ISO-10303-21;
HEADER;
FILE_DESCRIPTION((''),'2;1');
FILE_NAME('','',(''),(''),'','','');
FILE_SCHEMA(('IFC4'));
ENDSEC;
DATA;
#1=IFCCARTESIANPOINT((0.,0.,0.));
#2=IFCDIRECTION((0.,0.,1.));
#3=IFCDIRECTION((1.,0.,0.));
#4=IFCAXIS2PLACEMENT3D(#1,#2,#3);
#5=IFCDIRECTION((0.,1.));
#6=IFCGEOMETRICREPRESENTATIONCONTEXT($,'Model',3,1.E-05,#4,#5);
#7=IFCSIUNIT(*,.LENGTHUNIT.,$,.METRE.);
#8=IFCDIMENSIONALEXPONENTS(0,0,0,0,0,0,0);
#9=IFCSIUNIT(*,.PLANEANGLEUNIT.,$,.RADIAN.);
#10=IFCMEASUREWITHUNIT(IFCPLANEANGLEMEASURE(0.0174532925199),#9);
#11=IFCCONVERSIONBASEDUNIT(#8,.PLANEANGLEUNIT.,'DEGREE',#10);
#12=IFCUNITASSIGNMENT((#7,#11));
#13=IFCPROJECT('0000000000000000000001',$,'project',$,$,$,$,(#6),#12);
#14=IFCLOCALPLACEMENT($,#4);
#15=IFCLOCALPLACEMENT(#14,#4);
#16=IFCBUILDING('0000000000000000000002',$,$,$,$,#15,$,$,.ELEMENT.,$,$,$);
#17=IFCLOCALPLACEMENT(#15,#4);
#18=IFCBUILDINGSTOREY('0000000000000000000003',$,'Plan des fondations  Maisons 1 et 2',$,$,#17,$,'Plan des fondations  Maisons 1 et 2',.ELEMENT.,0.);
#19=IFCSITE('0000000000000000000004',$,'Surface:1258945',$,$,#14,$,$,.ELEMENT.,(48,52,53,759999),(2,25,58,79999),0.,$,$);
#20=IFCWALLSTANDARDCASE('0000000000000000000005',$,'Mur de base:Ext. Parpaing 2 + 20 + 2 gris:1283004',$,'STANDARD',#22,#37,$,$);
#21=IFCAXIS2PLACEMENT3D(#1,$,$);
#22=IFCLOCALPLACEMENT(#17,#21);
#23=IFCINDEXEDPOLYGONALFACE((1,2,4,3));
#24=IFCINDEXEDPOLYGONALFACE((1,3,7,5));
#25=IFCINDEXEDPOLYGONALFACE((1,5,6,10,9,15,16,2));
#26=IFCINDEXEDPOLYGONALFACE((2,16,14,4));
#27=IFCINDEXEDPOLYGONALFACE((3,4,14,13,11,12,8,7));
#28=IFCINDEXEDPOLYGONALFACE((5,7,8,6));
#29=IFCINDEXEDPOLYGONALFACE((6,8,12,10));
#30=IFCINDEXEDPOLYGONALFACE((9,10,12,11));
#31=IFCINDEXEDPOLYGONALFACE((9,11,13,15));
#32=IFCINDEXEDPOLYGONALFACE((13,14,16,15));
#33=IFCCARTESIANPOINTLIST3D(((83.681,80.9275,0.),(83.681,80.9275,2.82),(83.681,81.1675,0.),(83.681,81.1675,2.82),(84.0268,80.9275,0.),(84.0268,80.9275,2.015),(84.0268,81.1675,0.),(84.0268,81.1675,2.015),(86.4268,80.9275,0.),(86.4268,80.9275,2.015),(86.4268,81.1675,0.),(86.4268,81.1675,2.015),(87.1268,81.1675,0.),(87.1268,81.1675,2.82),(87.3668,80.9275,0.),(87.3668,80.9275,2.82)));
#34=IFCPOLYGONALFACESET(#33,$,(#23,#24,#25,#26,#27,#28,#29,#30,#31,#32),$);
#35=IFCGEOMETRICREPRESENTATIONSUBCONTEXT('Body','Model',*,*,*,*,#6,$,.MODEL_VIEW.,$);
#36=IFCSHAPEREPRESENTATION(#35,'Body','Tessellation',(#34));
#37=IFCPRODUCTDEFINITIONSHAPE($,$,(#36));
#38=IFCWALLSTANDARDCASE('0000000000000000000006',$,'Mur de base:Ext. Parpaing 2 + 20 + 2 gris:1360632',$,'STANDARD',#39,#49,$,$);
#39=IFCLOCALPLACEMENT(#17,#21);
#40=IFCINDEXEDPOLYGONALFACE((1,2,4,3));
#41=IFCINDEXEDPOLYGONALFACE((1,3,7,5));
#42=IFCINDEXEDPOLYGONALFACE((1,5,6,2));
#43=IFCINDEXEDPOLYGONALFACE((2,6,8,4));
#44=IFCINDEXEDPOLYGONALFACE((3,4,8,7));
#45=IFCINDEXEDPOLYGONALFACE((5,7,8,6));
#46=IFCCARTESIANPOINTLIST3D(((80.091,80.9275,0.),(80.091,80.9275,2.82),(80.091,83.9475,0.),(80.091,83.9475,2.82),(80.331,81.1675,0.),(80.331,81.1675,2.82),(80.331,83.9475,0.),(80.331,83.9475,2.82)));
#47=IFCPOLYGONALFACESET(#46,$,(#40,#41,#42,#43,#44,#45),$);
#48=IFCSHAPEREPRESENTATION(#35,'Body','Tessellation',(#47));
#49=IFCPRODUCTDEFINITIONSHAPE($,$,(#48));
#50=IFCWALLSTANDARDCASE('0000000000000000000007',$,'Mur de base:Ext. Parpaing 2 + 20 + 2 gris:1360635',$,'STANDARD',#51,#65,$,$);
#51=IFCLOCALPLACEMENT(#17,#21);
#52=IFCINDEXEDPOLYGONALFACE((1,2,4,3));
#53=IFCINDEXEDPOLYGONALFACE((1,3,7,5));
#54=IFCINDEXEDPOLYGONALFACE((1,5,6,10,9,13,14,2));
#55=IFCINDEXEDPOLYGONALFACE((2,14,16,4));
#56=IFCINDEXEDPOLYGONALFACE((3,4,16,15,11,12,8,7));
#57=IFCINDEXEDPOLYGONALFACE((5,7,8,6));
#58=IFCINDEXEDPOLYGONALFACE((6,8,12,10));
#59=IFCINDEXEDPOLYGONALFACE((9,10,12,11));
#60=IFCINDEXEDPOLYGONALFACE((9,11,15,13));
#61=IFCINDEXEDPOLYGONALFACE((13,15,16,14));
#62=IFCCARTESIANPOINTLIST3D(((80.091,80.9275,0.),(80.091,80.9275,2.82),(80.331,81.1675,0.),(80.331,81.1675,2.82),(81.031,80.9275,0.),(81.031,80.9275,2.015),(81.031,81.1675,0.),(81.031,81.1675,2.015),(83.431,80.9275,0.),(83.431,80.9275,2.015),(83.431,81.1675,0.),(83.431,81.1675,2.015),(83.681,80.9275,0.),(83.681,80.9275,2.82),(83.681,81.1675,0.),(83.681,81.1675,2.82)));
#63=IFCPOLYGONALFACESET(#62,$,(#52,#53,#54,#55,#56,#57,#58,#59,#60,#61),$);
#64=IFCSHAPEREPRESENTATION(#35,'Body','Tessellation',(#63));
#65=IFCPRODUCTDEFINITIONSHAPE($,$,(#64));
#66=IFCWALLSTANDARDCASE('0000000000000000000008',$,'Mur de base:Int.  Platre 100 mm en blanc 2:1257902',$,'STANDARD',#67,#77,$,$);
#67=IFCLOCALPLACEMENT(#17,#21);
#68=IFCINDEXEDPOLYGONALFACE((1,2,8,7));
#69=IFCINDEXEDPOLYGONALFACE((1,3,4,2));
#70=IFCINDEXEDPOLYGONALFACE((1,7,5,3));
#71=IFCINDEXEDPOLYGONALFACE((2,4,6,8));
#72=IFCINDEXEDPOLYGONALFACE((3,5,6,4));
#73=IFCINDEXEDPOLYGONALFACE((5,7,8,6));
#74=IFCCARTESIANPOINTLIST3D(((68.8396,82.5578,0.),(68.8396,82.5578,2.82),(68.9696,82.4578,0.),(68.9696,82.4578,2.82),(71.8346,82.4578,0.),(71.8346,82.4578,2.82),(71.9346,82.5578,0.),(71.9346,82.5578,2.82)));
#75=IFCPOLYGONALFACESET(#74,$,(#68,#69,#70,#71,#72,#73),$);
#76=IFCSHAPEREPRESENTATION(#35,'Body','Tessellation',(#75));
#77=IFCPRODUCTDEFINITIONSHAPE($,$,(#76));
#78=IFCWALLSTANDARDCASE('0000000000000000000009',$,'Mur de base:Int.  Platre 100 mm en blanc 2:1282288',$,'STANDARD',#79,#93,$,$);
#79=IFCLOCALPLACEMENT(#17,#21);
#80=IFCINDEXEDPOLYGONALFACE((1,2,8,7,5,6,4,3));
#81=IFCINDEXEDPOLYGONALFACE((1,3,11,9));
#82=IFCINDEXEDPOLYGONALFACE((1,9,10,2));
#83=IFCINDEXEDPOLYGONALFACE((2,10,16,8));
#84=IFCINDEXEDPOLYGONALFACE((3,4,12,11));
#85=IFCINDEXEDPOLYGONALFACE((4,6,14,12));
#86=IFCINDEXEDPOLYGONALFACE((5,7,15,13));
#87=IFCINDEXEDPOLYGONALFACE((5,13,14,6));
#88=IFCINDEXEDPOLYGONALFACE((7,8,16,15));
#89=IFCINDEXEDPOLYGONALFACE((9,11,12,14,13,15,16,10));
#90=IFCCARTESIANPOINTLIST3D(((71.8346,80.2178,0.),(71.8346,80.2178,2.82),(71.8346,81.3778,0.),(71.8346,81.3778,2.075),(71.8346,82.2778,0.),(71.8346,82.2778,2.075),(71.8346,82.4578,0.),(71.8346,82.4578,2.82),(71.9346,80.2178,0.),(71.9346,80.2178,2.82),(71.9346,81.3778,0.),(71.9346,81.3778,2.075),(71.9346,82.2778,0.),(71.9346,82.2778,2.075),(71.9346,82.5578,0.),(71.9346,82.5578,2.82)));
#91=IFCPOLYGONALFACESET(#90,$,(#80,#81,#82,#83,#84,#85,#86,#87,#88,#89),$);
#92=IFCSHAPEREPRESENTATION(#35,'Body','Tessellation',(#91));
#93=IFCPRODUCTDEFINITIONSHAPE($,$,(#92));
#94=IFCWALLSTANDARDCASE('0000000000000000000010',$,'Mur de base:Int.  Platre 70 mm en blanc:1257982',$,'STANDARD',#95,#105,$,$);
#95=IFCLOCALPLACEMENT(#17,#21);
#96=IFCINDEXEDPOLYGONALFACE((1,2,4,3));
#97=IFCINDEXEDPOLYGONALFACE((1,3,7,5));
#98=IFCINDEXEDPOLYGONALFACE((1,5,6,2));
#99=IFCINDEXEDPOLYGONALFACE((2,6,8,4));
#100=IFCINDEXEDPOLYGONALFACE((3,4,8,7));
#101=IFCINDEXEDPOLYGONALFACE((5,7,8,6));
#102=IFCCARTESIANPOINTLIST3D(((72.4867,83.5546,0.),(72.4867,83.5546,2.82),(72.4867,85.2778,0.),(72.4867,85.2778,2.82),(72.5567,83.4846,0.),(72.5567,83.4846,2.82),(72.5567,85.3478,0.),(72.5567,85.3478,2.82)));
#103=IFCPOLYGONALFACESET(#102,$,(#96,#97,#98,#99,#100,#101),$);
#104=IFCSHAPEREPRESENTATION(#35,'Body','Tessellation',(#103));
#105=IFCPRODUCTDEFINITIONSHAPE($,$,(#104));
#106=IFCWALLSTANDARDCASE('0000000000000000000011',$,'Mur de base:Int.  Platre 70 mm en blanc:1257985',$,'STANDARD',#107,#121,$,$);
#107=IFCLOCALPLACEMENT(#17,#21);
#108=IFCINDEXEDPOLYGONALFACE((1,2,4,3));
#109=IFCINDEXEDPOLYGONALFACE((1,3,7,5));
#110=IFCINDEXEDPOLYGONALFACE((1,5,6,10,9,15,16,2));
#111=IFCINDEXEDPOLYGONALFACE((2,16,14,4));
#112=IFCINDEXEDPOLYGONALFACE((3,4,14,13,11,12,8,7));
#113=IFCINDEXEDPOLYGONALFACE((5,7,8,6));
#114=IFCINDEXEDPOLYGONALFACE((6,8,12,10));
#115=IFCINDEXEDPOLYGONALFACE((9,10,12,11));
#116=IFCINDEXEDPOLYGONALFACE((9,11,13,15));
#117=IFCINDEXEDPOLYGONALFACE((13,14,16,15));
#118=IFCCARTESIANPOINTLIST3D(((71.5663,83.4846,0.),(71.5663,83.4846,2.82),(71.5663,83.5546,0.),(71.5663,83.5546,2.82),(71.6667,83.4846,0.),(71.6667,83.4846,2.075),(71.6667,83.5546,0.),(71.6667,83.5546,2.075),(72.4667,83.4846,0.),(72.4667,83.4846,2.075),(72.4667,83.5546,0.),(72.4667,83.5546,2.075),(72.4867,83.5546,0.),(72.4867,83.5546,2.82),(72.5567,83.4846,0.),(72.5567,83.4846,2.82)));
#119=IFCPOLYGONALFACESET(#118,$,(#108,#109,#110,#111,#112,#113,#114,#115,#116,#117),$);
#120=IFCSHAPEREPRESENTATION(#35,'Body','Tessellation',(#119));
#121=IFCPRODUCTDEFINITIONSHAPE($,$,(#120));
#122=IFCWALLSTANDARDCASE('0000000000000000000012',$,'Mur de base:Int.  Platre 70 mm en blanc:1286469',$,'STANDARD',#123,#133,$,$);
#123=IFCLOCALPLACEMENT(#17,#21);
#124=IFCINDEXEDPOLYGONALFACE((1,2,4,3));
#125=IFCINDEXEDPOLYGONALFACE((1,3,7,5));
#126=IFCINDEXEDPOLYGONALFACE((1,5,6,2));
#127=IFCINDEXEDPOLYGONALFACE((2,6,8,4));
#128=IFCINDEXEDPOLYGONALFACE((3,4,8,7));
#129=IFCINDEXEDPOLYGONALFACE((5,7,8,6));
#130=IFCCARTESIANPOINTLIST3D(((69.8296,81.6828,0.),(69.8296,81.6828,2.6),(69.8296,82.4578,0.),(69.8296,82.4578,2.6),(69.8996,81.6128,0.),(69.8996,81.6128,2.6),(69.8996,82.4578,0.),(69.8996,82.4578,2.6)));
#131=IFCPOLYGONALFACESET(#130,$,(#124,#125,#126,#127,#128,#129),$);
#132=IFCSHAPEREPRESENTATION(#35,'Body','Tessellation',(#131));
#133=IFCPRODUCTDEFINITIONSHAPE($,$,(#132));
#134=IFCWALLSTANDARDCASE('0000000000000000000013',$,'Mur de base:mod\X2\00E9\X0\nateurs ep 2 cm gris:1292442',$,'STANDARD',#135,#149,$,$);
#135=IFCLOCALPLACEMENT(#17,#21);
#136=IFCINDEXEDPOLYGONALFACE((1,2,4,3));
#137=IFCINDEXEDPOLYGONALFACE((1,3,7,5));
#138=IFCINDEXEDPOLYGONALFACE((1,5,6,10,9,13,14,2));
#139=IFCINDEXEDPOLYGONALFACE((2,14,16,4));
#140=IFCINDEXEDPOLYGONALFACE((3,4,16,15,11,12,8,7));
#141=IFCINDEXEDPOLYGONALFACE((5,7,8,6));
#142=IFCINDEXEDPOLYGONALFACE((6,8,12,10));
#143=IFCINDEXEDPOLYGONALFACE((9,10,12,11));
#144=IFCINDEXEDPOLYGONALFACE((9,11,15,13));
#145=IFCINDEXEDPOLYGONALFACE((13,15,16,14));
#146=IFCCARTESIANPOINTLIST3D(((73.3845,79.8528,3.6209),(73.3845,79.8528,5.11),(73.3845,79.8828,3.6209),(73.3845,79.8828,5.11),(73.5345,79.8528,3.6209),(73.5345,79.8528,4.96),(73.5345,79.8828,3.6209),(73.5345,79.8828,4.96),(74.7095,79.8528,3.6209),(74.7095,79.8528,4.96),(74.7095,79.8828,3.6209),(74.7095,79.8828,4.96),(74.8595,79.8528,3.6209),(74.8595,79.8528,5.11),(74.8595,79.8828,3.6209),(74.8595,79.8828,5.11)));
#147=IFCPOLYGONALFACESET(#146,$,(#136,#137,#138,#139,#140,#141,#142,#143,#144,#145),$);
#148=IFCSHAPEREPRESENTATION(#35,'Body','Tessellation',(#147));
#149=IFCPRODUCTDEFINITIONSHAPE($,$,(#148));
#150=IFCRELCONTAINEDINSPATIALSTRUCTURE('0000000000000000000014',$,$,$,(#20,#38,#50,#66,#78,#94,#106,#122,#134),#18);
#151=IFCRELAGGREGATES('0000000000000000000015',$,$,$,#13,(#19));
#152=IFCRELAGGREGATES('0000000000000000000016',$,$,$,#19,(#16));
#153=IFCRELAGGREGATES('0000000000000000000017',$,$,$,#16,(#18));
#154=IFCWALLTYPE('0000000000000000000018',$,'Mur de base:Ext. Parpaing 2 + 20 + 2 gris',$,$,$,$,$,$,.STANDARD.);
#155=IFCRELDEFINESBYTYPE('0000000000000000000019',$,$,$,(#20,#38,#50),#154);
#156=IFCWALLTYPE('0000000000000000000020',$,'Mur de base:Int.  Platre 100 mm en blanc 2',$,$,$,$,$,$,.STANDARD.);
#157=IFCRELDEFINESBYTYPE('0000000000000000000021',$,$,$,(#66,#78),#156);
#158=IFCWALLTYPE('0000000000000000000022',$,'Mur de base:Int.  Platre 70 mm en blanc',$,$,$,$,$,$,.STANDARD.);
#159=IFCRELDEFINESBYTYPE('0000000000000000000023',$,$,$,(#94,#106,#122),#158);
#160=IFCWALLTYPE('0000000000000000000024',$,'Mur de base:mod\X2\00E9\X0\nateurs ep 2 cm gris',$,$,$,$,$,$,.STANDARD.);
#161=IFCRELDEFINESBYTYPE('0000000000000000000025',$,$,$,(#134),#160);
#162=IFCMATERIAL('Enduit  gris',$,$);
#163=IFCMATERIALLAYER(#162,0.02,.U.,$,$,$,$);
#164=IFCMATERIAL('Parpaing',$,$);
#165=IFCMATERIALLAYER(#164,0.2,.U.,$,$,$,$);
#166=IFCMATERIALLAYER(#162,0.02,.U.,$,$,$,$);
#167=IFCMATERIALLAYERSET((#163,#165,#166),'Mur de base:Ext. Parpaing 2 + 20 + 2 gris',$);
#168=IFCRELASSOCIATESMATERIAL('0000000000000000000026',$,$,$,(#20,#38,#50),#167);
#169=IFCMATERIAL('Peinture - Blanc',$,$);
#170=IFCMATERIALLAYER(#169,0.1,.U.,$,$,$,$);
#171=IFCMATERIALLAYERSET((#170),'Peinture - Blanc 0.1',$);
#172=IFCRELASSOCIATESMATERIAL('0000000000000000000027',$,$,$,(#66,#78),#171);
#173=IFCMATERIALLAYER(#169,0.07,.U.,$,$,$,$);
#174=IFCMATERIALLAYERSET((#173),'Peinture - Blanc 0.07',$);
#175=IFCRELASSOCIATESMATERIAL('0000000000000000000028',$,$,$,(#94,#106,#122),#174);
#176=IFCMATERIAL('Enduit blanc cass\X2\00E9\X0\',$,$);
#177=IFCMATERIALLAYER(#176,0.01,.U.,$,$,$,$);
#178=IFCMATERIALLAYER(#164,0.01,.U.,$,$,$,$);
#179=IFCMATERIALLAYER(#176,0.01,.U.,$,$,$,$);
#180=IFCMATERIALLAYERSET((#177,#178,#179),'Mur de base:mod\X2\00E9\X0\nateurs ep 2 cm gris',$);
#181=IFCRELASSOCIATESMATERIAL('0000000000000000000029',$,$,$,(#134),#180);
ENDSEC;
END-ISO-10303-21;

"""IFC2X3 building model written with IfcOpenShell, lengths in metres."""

from ifc_helpers import new_model, entity, si_unit, converted_unit, direction, frame, origin_with_axes, origin_2d_with_axis, place, context, subcontext, project, spatial, polyline, rectangle, outline, extrude, clip, halfspace, material, layer, layer_set, layer_usage, type_object, element, save


model = new_model("IFC2X3")

# Units and contexts
model_context = context("Model", 3, precision=1e-05, world=origin_with_axes(), true_north=direction((0.0, 1.0)))
body_context = subcontext(model_context, "Body", "Model", "MODEL_VIEW")
ifc_project = project(units=[si_unit("LENGTHUNIT", "METRE"), converted_unit("PLANEANGLEUNIT", "DEGREE", entity("IfcPlaneAngleMeasure", 0.0174532925199), si_unit("PLANEANGLEUNIT", "RADIAN"), dimensions=[0, 0, 0, 0, 0, 0, 0])], contexts=[model_context])

# Site, building, storey
site_placement = place(None, origin_with_axes())
site = spatial("IfcSite", under=ifc_project, at=site_placement, Name="Surface:1258945", CompositionType="ELEMENT", RefLatitude=(48, 52, 53, 759999), RefLongitude=(2, 25, 58, 79999), RefElevation=0.0)
building_placement = place(site_placement, origin_with_axes())
building = spatial("IfcBuilding", under=site, at=building_placement, CompositionType="ELEMENT")
storey_placement = place(building_placement, origin_with_axes())
storey = spatial("IfcBuildingStorey", under=building, at=storey_placement, Name="Plan des fondations  Maisons 1 et 2", LongName="Plan des fondations  Maisons 1 et 2", CompositionType="ELEMENT", Elevation=0.0)

# Shared definitions
ifc_material_1 = material(Name="Parpaing")
ifc_material_2 = material(Name="Enduit  gris")
ifc_layer_1 = layer(ifc_material_2, 0.02, ventilated="UNKNOWN")
ifc_layer_2 = layer(ifc_material_1, 0.2, ventilated="UNKNOWN")
ifc_layer_3 = layer(ifc_material_2, 0.02, ventilated="UNKNOWN")
ifc_layer_set_1 = layer_set([ifc_layer_1, ifc_layer_2, ifc_layer_3], Name="Mur de base:Ext. Parpaing 2 + 20 + 2 gris")
wall_type_1 = type_object("IfcWallType", Name="Mur de base:Ext. Parpaing 2 + 20 + 2 gris", PredefinedType="STANDARD")

# Wall, opening
ifc_layer_usage_1 = layer_usage(ifc_layer_set_1, "AXIS2", "POSITIVE", -0.12)
wall_1_placement = place(storey_placement, frame((83.681, 81.0475, 0.0), z_axis=(0.0, 0.0, 1.0), x_axis=(1.0, 0.0, 0.0)))
wall_1 = element("IfcWallStandardCase", 1, at=wall_1_placement, inside=storey, type_object=wall_type_1, material=ifc_layer_usage_1, Name="Mur de base:Ext. Parpaing 2 + 20 + 2 gris:1283004", ObjectType="STANDARD", context=body_context, shape_type="SweptSolid", body=[
    extrude(outline(polyline([(0.0, -0.12), (3.6858, -0.12), (3.4458, 0.12), (0.0, 0.12), (0.0, -0.12)])), origin_with_axes(), (0.0, 0.0, 1.0), 2.82),
])
opening_1_placement = place(wall_1_placement, frame((1.5458, 0.0, 0.0), z_axis=(0.0, 0.0, 1.0), x_axis=(1.0, 0.0, 0.0)))
element("IfcOpeningElement", 2, at=opening_1_placement, cuts=wall_1, context=body_context, shape_type="SweptSolid", body=[
    extrude(outline(polyline([(-1.2, 2.015), (-1.2, 0.0), (1.2, 0.0), (1.2, 2.015), (-1.2, 2.015)])), frame((0.0, -0.42, 0.0), z_axis=(0.0, 1.0, 0.0), x_axis=(-1.0, 0.0, 0.0)), (0.0, 0.0, 1.0), 0.84),
])

# Wall
ifc_layer_usage_2 = layer_usage(ifc_layer_set_1, "AXIS2", "POSITIVE", -0.12)
wall_2_placement = place(storey_placement, frame((80.211, 81.0475, 0.0), z_axis=(0.0, 0.0, 1.0), x_axis=(0.0, 1.0, 0.0)))
element("IfcWallStandardCase", 3, at=wall_2_placement, inside=storey, type_object=wall_type_1, material=ifc_layer_usage_2, Name="Mur de base:Ext. Parpaing 2 + 20 + 2 gris:1360632", ObjectType="STANDARD", context=body_context, shape_type="SweptSolid", body=[
    extrude(outline(polyline([(0.12, -0.12), (2.9, -0.12), (2.9, 0.12), (-0.12, 0.12), (0.12, -0.12)])), origin_with_axes(), (0.0, 0.0, 1.0), 2.82),
])

# Wall, opening
ifc_layer_usage_3 = layer_usage(ifc_layer_set_1, "AXIS2", "POSITIVE", -0.12)
wall_3_placement = place(storey_placement, frame((83.681, 81.0475, 0.0), z_axis=(0.0, 0.0, 1.0), x_axis=(-1.0, 0.0, 0.0)))
wall_3 = element("IfcWallStandardCase", 4, at=wall_3_placement, inside=storey, type_object=wall_type_1, material=ifc_layer_usage_3, Name="Mur de base:Ext. Parpaing 2 + 20 + 2 gris:1360635", ObjectType="STANDARD", context=body_context, shape_type="SweptSolid", body=[
    extrude(outline(polyline([(0.0, -0.12), (3.35, -0.12), (3.59, 0.12), (0.0, 0.12), (0.0, -0.12)])), origin_with_axes(), (0.0, 0.0, 1.0), 2.82),
])
opening_2_placement = place(wall_3_placement, frame((1.45, 0.0, 0.0), z_axis=(0.0, 0.0, 1.0), x_axis=(1.0, 0.0, 0.0)))
element("IfcOpeningElement", 5, at=opening_2_placement, cuts=wall_3, context=body_context, shape_type="SweptSolid", body=[
    extrude(outline(polyline([(1.2, -2.015), (1.2, 0.0), (-1.2, 0.0), (-1.2, -2.015), (1.2, -2.015)])), frame((0.0, -0.42, 0.0), z_axis=(0.0, 1.0, 0.0), x_axis=(1.0, 0.0, 0.0)), (0.0, 0.0, 1.0), 0.84),
])

# Wall
ifc_material_3 = material(Name="Peinture - Blanc")
ifc_layer_4 = layer(ifc_material_3, 0.1, ventilated="UNKNOWN")
ifc_layer_set_2 = layer_set([ifc_layer_4], Name="Peinture - Blanc 0.1")
ifc_layer_usage_4 = layer_usage(ifc_layer_set_2, "AXIS2", "POSITIVE", -0.05)
wall_type_2 = type_object("IfcWallType", Name="Mur de base:Int.  Platre 100 mm en blanc 2", PredefinedType="STANDARD")
wall_4_placement = place(storey_placement, frame((71.8846, 82.5078, 0.0), z_axis=(0.0, 0.0, 1.0), x_axis=(-1.0, 0.0, 0.0)))
element("IfcWallStandardCase", 6, at=wall_4_placement, inside=storey, type_object=wall_type_2, material=ifc_layer_usage_4, Name="Mur de base:Int.  Platre 100 mm en blanc 2:1257902", ObjectType="STANDARD", context=body_context, shape_type="SweptSolid", body=[
    extrude(outline(polyline([(-0.05, -0.05), (3.045, -0.05), (2.915, 0.05), (0.05, 0.05), (-0.05, -0.05)])), origin_with_axes(), (0.0, 0.0, 1.0), 2.82),
])

# Wall, opening
ifc_layer_usage_5 = layer_usage(ifc_layer_set_2, "AXIS2", "POSITIVE", -0.05)
wall_5_placement = place(storey_placement, frame((71.8846, 80.2178, 0.0), z_axis=(0.0, 0.0, 1.0), x_axis=(0.0, 1.0, 0.0)))
wall_5 = element("IfcWallStandardCase", 7, at=wall_5_placement, inside=storey, type_object=wall_type_2, material=ifc_layer_usage_5, Name="Mur de base:Int.  Platre 100 mm en blanc 2:1282288", ObjectType="STANDARD", context=body_context, shape_type="SweptSolid", body=[
    extrude(outline(polyline([(0.0, -0.05), (2.34, -0.05), (2.24, 0.05), (0.0, 0.05), (0.0, -0.05)])), origin_with_axes(), (0.0, 0.0, 1.0), 2.82),
])
opening_3_placement = place(wall_5_placement, frame((1.61, 0.0, 0.0), z_axis=(0.0, 0.0, 1.0), x_axis=(1.0, 0.0, 0.0)))
element("IfcOpeningElement", 8, at=opening_3_placement, cuts=wall_5, context=body_context, shape_type="SweptSolid", body=[
    extrude(outline(polyline([(0.45, 0.0), (0.45, 2.075), (-0.45, 2.075), (-0.45, 0.0), (0.45, 0.0)])), frame((0.0, -0.05, 0.0), z_axis=(0.0, 1.0, 0.0), x_axis=(-1.0, 0.0, 0.0)), (0.0, 0.0, 1.0), 0.1),
])

# Wall
ifc_layer_5 = layer(ifc_material_3, 0.07, ventilated="UNKNOWN")
ifc_layer_set_3 = layer_set([ifc_layer_5], Name="Peinture - Blanc 0.07")
ifc_layer_usage_6 = layer_usage(ifc_layer_set_3, "AXIS2", "POSITIVE", -0.035)
wall_type_3 = type_object("IfcWallType", Name="Mur de base:Int.  Platre 70 mm en blanc", PredefinedType="STANDARD")
wall_6_placement = place(storey_placement, frame((72.5217, 83.5196, 0.0), z_axis=(0.0, 0.0, 1.0), x_axis=(0.0, 1.0, 0.0)))
element("IfcWallStandardCase", 9, at=wall_6_placement, inside=storey, type_object=wall_type_3, material=ifc_layer_usage_6, Name="Mur de base:Int.  Platre 70 mm en blanc:1257982", ObjectType="STANDARD", context=body_context, shape_type="SweptSolid", body=[
    extrude(outline(polyline([(-0.035, -0.035), (1.8281, -0.035), (1.7581, 0.035), (0.035, 0.035), (-0.035, -0.035)])), origin_with_axes(), (0.0, 0.0, 1.0), 2.82),
])

# Wall, opening
ifc_layer_usage_7 = layer_usage(ifc_layer_set_3, "AXIS2", "POSITIVE", -0.035)
wall_7_placement = place(storey_placement, frame((71.5663, 83.5196, 0.0), z_axis=(0.0, 0.0, 1.0), x_axis=(1.0, 0.0, 0.0)))
wall_7 = element("IfcWallStandardCase", 10, at=wall_7_placement, inside=storey, type_object=wall_type_3, material=ifc_layer_usage_7, Name="Mur de base:Int.  Platre 70 mm en blanc:1257985", ObjectType="STANDARD", context=body_context, shape_type="SweptSolid", body=[
    extrude(outline(polyline([(0.0, -0.035), (0.9904, -0.035), (0.9204, 0.035), (0.0, 0.035), (0.0, -0.035)])), origin_with_axes(), (0.0, 0.0, 1.0), 2.82),
])
opening_4_placement = place(wall_7_placement, frame((0.5004, 0.0, 0.0), z_axis=(0.0, 0.0, 1.0), x_axis=(1.0, 0.0, 0.0)))
element("IfcOpeningElement", 11, at=opening_4_placement, cuts=wall_7, context=body_context, shape_type="SweptSolid", body=[
    extrude(outline(polyline([(-0.4, 0.0), (0.4, 0.0), (0.4, 2.075), (-0.4, 2.075), (-0.4, 0.0)])), frame((0.0, 0.035, 0.0), z_axis=(0.0, 1.0, 0.0), x_axis=(-1.0, 0.0, 0.0)), (0.0, 0.0, -1.0), 0.07),
])

# Wall
ifc_layer_usage_8 = layer_usage(ifc_layer_set_3, "AXIS2", "POSITIVE", -0.035)
wall_8_placement = place(storey_placement, frame((69.8646, 81.6478, 0.0), z_axis=(0.0, 0.0, 1.0), x_axis=(0.0, 1.0, 0.0)))
element("IfcWallStandardCase", 12, at=wall_8_placement, inside=storey, type_object=wall_type_3, material=ifc_layer_usage_8, Name="Mur de base:Int.  Platre 70 mm en blanc:1286469", ObjectType="STANDARD", context=body_context, shape_type="SweptSolid", body=[
    extrude(outline(polyline([(-0.035, -0.035), (0.81, -0.035), (0.81, 0.035), (0.035, 0.035), (-0.035, -0.035)])), origin_with_axes(), (0.0, 0.0, 1.0), 2.6),
])

# Wall, opening
ifc_material_4 = material(Name="Enduit blanc cassé")
ifc_layer_6 = layer(ifc_material_4, 0.01, ventilated="UNKNOWN")
ifc_layer_7 = layer(ifc_material_1, 0.01, ventilated="UNKNOWN")
ifc_layer_8 = layer(ifc_material_4, 0.01, ventilated="UNKNOWN")
ifc_layer_set_4 = layer_set([ifc_layer_6, ifc_layer_7, ifc_layer_8], Name="Mur de base:modénateurs ep 2 cm gris")
wall_type_4 = type_object("IfcWallType", Name="Mur de base:modénateurs ep 2 cm gris", PredefinedType="STANDARD")
ifc_layer_usage_9 = layer_usage(ifc_layer_set_4, "AXIS2", "POSITIVE", -0.015)
wall_9_placement = place(storey_placement, frame((73.3845, 79.8678, 3.6209), z_axis=(0.0, 0.0, 1.0), x_axis=(1.0, 0.0, 0.0)))
wall_9 = element("IfcWallStandardCase", 13, at=wall_9_placement, inside=storey, type_object=wall_type_4, material=ifc_layer_usage_9, Name="Mur de base:modénateurs ep 2 cm gris:1292442", ObjectType="STANDARD", context=body_context, shape_type="Clipping", body=[
    clip(extrude(outline(polyline([(0.0, -0.015), (1.475, -0.015), (1.475, 0.015), (0.0, 0.015), (0.0, -0.015)])), origin_with_axes(), (0.0, 0.0, 1.0), 1.4891), halfspace(frame((0.0, 0.0, 0.0), z_axis=(0.0, 0.0, 1.0), x_axis=(0.0, -1.0, 0.0)), True)),
])
opening_5_placement = place(wall_9_placement, frame((-73.3845, -79.8678, -3.6209), z_axis=(0.0, 0.0, 1.0), x_axis=(1.0, 0.0, 0.0)))
element("IfcOpeningElement", 14, at=opening_5_placement, cuts=wall_9, context=body_context, shape_type="SweptSolid", body=[
    extrude(rectangle(XDim=1.3391, YDim=1.175, at=origin_2d_with_axis()), frame((74.122, 79.8828, 4.2904), z_axis=(0.0, -1.0, 0.0), x_axis=(0.0, 0.0, 1.0)), (0.0, 0.0, 1.0), 0.03),
])

save(model, "model.ifc")
